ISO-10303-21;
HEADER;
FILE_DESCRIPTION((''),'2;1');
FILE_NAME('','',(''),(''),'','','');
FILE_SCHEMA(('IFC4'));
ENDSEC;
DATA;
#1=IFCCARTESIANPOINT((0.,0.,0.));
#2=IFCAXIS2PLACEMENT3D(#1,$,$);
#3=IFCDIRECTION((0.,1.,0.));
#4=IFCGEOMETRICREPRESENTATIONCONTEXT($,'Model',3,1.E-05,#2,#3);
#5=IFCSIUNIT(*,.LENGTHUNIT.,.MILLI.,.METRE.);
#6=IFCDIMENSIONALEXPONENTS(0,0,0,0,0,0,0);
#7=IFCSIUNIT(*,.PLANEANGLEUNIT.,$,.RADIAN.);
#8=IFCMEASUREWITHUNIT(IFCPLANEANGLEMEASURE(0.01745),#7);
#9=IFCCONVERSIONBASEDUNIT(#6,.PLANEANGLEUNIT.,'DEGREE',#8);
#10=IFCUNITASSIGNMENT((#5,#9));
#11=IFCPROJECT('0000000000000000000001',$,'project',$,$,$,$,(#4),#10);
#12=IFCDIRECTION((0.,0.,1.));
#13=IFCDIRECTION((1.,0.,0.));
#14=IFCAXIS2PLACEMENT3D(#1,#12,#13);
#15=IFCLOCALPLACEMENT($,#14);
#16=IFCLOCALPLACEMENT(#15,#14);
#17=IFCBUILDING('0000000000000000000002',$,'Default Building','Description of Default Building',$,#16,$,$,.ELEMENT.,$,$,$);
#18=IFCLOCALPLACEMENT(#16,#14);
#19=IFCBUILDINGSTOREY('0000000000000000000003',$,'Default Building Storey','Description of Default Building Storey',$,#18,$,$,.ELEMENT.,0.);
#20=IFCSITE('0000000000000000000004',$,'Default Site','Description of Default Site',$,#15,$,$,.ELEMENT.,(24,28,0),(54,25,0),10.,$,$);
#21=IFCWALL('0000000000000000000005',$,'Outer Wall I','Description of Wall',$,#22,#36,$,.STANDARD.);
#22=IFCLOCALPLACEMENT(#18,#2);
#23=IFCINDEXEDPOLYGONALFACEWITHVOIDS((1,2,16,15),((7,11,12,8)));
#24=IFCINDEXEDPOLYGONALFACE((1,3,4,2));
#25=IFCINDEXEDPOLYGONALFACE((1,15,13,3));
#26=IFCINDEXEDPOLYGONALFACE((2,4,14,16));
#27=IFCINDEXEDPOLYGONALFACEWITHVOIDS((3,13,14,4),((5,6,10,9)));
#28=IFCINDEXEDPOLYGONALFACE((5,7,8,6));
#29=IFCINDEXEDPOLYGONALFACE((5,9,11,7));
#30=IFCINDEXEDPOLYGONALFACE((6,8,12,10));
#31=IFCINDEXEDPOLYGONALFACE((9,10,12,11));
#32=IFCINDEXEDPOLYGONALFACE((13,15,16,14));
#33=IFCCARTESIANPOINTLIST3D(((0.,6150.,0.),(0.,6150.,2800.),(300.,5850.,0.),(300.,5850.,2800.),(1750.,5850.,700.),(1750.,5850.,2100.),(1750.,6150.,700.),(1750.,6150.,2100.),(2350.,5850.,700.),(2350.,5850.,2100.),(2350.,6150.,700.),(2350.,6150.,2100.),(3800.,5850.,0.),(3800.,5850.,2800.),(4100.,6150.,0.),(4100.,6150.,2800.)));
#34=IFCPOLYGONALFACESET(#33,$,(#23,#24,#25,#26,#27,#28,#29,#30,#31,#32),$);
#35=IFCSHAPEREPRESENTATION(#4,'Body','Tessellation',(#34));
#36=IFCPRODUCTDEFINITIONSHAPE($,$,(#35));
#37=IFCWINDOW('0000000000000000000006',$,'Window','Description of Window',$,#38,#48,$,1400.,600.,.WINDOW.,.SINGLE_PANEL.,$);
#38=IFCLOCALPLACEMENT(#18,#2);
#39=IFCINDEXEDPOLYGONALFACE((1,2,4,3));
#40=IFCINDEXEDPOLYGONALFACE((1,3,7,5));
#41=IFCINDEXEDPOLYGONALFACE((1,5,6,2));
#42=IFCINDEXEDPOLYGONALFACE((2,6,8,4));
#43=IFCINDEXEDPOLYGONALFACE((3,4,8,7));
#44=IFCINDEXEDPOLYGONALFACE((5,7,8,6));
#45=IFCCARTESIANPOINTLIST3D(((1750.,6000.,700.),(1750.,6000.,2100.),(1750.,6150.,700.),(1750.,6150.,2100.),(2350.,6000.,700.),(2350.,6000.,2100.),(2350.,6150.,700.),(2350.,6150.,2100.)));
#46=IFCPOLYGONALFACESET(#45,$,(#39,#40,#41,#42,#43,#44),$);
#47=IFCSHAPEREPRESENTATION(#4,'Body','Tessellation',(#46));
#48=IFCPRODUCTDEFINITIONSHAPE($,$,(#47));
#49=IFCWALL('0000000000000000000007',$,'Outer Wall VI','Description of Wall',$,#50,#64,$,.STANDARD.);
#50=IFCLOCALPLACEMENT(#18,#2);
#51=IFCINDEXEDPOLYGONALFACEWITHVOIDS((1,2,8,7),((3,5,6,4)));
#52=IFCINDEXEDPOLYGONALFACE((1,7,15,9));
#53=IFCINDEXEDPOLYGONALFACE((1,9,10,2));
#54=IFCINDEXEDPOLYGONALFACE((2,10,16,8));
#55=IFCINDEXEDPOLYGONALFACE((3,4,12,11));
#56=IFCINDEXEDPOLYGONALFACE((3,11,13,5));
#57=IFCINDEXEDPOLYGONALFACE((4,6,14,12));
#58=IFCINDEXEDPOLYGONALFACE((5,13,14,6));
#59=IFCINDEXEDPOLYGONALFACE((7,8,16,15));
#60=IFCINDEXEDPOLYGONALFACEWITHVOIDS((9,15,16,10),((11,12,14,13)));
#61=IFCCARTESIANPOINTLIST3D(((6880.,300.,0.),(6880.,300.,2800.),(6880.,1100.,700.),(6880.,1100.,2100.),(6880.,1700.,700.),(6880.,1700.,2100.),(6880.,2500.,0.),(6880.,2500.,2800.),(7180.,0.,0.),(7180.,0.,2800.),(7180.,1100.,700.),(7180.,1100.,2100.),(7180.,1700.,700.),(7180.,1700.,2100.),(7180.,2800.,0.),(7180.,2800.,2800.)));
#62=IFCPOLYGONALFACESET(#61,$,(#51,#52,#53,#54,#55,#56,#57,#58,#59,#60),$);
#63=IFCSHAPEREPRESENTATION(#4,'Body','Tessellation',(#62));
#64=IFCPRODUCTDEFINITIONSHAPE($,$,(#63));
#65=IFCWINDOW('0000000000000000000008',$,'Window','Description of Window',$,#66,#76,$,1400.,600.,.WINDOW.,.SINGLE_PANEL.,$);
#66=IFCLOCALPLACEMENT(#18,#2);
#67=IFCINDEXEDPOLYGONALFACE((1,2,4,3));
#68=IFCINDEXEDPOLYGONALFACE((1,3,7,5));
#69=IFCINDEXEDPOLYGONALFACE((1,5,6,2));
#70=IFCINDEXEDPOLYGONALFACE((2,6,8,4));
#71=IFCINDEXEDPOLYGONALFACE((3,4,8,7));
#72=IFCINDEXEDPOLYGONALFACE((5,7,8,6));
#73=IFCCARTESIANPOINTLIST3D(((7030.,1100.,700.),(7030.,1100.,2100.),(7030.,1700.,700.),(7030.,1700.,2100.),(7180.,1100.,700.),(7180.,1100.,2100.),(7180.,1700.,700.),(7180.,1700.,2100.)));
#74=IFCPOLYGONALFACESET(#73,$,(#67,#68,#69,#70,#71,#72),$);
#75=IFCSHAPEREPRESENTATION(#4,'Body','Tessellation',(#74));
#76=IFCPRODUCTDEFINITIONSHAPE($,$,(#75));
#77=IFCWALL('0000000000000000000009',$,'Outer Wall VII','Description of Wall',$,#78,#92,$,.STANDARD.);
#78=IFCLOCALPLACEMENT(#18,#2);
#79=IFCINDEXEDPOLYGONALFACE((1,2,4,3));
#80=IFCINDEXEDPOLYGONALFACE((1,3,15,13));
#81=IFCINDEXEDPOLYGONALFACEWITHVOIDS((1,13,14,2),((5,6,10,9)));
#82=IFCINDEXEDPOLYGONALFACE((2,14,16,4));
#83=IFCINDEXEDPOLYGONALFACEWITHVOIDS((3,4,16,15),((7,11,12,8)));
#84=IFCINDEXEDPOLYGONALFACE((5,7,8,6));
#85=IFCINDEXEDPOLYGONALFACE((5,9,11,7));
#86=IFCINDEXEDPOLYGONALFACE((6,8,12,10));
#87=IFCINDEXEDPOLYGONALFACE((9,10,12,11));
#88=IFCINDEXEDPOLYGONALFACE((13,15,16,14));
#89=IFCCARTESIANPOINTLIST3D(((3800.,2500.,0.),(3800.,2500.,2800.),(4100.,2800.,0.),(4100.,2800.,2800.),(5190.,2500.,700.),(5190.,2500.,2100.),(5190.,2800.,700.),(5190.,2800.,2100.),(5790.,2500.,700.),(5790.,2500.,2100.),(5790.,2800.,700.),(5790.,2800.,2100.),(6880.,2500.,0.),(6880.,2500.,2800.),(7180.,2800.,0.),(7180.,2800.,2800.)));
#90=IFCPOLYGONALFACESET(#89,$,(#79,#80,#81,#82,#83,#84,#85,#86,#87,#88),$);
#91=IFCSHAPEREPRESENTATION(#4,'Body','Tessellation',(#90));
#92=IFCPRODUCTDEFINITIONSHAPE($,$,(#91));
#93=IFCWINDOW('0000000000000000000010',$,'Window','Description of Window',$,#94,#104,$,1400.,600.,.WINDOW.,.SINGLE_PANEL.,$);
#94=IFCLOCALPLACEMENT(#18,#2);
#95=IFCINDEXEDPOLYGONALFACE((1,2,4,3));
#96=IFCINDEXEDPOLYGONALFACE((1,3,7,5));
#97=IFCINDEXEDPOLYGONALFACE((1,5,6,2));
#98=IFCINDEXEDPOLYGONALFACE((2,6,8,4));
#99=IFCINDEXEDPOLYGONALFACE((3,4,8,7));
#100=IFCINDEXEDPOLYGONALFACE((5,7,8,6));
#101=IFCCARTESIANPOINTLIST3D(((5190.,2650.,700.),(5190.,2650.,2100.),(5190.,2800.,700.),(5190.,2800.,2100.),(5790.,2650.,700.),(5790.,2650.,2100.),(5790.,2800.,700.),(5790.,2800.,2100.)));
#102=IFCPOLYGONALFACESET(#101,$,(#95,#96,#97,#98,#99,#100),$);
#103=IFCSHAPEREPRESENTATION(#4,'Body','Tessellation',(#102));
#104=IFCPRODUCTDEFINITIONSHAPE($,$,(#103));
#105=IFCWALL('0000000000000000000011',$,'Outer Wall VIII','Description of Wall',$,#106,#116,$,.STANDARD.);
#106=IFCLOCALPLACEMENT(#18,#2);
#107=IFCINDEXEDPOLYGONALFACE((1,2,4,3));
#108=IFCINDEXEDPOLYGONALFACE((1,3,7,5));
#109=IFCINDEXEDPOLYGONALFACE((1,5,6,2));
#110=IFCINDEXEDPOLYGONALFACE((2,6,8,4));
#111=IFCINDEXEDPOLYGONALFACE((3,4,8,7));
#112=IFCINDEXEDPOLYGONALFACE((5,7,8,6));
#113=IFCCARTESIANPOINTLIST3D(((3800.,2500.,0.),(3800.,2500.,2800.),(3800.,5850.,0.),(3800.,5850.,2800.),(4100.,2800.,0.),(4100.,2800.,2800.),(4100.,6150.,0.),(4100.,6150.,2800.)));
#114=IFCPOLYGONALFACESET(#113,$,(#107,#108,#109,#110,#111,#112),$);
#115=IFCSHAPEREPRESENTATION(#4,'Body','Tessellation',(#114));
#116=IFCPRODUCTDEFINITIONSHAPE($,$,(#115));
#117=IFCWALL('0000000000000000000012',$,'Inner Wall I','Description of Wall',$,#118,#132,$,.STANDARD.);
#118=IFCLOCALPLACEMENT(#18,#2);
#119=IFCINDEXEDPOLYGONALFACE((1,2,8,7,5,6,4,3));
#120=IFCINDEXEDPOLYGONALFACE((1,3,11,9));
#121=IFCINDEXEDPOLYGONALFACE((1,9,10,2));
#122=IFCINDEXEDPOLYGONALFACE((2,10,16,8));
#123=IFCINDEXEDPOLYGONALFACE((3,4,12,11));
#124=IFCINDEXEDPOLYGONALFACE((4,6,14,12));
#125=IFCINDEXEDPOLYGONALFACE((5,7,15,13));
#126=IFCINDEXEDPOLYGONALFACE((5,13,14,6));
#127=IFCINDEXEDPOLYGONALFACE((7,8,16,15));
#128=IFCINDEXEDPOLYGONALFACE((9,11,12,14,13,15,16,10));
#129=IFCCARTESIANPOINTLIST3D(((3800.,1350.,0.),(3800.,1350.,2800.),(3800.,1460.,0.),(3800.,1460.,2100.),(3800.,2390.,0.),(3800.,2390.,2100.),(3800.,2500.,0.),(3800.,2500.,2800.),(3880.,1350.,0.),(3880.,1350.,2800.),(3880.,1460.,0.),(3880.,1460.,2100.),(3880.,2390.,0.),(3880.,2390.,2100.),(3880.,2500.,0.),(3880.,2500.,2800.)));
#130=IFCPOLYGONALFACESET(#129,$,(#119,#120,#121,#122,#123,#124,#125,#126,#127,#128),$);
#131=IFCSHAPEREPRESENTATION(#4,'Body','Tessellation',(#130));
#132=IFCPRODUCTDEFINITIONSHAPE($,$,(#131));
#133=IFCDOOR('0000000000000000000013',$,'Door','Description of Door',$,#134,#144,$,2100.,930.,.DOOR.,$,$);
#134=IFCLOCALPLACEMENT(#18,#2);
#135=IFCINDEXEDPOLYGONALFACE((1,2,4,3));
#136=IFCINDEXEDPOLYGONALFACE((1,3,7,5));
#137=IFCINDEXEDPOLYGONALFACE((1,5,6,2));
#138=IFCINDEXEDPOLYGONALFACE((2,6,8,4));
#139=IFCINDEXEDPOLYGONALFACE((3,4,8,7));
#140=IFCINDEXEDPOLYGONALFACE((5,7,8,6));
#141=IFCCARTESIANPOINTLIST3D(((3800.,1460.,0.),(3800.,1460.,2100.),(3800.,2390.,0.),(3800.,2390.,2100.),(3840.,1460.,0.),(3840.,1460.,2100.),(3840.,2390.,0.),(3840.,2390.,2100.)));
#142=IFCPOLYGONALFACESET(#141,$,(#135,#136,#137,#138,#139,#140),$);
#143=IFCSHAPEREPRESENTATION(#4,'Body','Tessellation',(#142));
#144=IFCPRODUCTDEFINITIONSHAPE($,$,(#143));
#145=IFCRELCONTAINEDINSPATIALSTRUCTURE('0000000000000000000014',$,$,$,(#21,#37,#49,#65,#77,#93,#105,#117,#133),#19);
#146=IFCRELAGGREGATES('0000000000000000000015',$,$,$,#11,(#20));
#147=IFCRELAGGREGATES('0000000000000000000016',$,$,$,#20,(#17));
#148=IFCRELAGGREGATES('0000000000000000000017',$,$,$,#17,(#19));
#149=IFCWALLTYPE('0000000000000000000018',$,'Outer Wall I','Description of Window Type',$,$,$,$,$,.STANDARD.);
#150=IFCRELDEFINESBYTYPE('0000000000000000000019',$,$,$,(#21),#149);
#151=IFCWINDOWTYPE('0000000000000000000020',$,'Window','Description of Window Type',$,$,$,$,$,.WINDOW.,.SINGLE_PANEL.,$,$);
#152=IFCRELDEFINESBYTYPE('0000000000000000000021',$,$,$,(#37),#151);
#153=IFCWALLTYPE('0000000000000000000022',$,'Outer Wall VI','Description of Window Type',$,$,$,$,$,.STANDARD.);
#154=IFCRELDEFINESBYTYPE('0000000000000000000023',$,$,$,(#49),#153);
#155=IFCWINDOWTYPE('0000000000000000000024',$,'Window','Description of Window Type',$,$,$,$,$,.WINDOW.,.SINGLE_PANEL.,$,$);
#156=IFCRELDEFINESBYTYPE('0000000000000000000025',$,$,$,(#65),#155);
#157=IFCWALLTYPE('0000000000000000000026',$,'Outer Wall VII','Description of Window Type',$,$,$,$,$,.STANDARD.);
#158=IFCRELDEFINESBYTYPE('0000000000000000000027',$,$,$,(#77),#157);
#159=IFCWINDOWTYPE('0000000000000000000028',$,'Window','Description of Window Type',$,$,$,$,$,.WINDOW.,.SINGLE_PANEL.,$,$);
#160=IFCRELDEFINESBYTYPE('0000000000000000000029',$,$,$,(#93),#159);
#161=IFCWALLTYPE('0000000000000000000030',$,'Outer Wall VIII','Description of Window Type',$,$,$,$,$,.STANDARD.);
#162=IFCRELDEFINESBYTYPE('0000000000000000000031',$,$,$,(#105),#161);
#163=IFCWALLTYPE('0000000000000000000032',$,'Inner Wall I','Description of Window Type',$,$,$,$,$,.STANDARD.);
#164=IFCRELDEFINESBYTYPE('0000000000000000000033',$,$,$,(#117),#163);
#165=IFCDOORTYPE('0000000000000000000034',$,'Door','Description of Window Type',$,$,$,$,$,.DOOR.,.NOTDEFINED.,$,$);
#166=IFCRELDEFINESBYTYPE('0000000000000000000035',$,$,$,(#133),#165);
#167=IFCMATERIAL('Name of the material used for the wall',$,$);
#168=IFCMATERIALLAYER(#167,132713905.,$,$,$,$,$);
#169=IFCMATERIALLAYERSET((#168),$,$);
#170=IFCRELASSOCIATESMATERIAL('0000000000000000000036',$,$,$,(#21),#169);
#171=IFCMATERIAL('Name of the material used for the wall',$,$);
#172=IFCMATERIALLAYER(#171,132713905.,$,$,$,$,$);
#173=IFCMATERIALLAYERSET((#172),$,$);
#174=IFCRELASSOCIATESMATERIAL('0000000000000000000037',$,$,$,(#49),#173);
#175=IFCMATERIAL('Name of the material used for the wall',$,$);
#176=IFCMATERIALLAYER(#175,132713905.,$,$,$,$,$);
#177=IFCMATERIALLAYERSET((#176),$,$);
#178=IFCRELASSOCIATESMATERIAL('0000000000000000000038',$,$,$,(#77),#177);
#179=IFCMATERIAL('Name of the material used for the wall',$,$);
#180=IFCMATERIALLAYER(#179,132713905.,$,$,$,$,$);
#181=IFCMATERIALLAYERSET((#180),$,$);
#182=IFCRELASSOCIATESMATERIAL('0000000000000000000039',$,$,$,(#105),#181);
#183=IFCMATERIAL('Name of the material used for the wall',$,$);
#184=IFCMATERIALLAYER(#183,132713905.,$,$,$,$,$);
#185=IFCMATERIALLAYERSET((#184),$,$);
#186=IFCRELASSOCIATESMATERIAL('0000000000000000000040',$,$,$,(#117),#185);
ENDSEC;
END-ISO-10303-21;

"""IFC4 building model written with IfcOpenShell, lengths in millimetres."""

from ifc_helpers import new_model, entity, si_unit, converted_unit, direction, frame, origin, origin_with_axes, place, context, project, spatial, polyline, outline, extrude, material, layer, layer_set, layer_usage, type_object, element, fill, save


model = new_model("IFC4")

# Units and contexts
model_context = context("Model", 3, precision=1e-05, world=origin(), true_north=direction((0.0, 1.0, 0.0)))
ifc_project = project(units=[si_unit("LENGTHUNIT", "METRE", prefix="MILLI"), converted_unit("PLANEANGLEUNIT", "DEGREE", entity("IfcPlaneAngleMeasure", 0.01745), si_unit("PLANEANGLEUNIT", "RADIAN"), dimensions=[0, 0, 0, 0, 0, 0, 0])], contexts=[model_context])

# Site, building, storey
site_placement = place(None, origin_with_axes())
site = spatial("IfcSite", under=ifc_project, at=site_placement, Name="Default Site", Description="Description of Default Site", CompositionType="ELEMENT", RefLatitude=(24, 28, 0), RefLongitude=(54, 25, 0), RefElevation=10.0)
building_placement = place(site_placement, origin_with_axes())
building = spatial("IfcBuilding", under=site, at=building_placement, Name="Default Building", Description="Description of Default Building", CompositionType="ELEMENT")
storey_placement = place(building_placement, origin_with_axes())
storey = spatial("IfcBuildingStorey", under=building, at=storey_placement, Name="Default Building Storey", Description="Description of Default Building Storey", CompositionType="ELEMENT", Elevation=0.0)

# Walls, openings, windows
ifc_material_1 = material(Name="Name of the material used for the wall")
ifc_layer_1 = layer(ifc_material_1, 132713905.0)
ifc_layer_set_1 = layer_set([ifc_layer_1])
ifc_layer_usage_1 = layer_usage(ifc_layer_set_1, "AXIS2", "POSITIVE", -66356952.5)
wall_type_1 = type_object("IfcWallType", Name="Outer Wall I", Description="Description of Window Type", PredefinedType="STANDARD")
wall_1_placement = place(storey_placement, frame((3950.0, 6000.0, 0.0), z_axis=(0.0, 0.0, 1.0), x_axis=(-1.0, 0.0, 0.0)))
wall_1 = element("IfcWall", 1, at=wall_1_placement, inside=storey, type_object=wall_type_1, material=ifc_layer_usage_1, Name="Outer Wall I", Description="Description of Wall", PredefinedType="STANDARD", context=model_context, shape_type="SweptSolid", body=[
    extrude(outline(polyline([(-150.0, -150.0), (150.0, 150.0), (3650.0, 150.0), (3950.0, -150.0), (-150.0, -150.0)])), origin_with_axes(), (0.0, 0.0, 1.0), 2800.0),
])
opening_1_placement = place(wall_1_placement, frame((1600.0, -150.0, 700.0), z_axis=(0.0, 0.0, 1.0), x_axis=(1.0, 0.0, 0.0)))
opening_1 = element("IfcOpeningElement", 2, at=opening_1_placement, cuts=wall_1, context=model_context, shape_type="SweptSolid", body=[
    extrude(outline(polyline([(0.0, 0.0), (0.0, 300.0), (600.0, 300.0), (600.0, 0.0), (0.0, 0.0)])), origin_with_axes(), (0.0, 0.0, 1.0), 1400.0),
])
window_type_1 = type_object("IfcWindowType", Name="Window", Description="Description of Window Type", PartitioningType="SINGLE_PANEL", PredefinedType="WINDOW")
window_1_placement = place(opening_1_placement, origin_with_axes())
window_1 = element("IfcWindow", 3, at=window_1_placement, inside=storey, type_object=window_type_1, Name="Window", Description="Description of Window", OverallHeight=1400.0, OverallWidth=600.0, PartitioningType="SINGLE_PANEL", PredefinedType="WINDOW", context=model_context, shape_type="SweptSolid", body=[
    extrude(outline(polyline([(0.0, 0.0), (0.0, 150.0), (600.0, 150.0), (600.0, 0.0), (0.0, 0.0)])), origin_with_axes(), (0.0, 0.0, 1.0), 1400.0),
])
fill(opening_1, window_1)
ifc_material_2 = material(Name="Name of the material used for the wall")
ifc_layer_2 = layer(ifc_material_2, 132713905.0)
ifc_layer_set_2 = layer_set([ifc_layer_2])
ifc_layer_usage_2 = layer_usage(ifc_layer_set_2, "AXIS2", "POSITIVE", -66356952.5)
wall_type_2 = type_object("IfcWallType", Name="Outer Wall VI", Description="Description of Window Type", PredefinedType="STANDARD")
wall_2_placement = place(storey_placement, frame((7030.0, 150.0, 0.0), z_axis=(0.0, 0.0, 1.0), x_axis=(0.0, 1.0, 0.0)))
wall_2 = element("IfcWall", 4, at=wall_2_placement, inside=storey, type_object=wall_type_2, material=ifc_layer_usage_2, Name="Outer Wall VI", Description="Description of Wall", PredefinedType="STANDARD", context=model_context, shape_type="SweptSolid", body=[
    extrude(outline(polyline([(-150.0, -150.0), (150.0, 150.0), (2350.0, 150.0), (2650.0, -150.0), (-150.0, -150.0)])), origin_with_axes(), (0.0, 0.0, 1.0), 2800.0),
])
opening_2_placement = place(wall_2_placement, frame((950.0, -150.0, 700.0), z_axis=(0.0, 0.0, 1.0), x_axis=(1.0, 0.0, 0.0)))
opening_2 = element("IfcOpeningElement", 5, at=opening_2_placement, cuts=wall_2, context=model_context, shape_type="SweptSolid", body=[
    extrude(outline(polyline([(0.0, 0.0), (0.0, 300.0), (600.0, 300.0), (600.0, 0.0), (0.0, 0.0)])), origin_with_axes(), (0.0, 0.0, 1.0), 1400.0),
])
window_type_2 = type_object("IfcWindowType", Name="Window", Description="Description of Window Type", PartitioningType="SINGLE_PANEL", PredefinedType="WINDOW")
window_2_placement = place(opening_2_placement, origin_with_axes())
window_2 = element("IfcWindow", 6, at=window_2_placement, inside=storey, type_object=window_type_2, Name="Window", Description="Description of Window", OverallHeight=1400.0, OverallWidth=600.0, PartitioningType="SINGLE_PANEL", PredefinedType="WINDOW", context=model_context, shape_type="SweptSolid", body=[
    extrude(outline(polyline([(0.0, 0.0), (0.0, 150.0), (600.0, 150.0), (600.0, 0.0), (0.0, 0.0)])), origin_with_axes(), (0.0, 0.0, 1.0), 1400.0),
])
fill(opening_2, window_2)
ifc_material_3 = material(Name="Name of the material used for the wall")
ifc_layer_3 = layer(ifc_material_3, 132713905.0)
ifc_layer_set_3 = layer_set([ifc_layer_3])
ifc_layer_usage_3 = layer_usage(ifc_layer_set_3, "AXIS2", "POSITIVE", -66356952.5)
wall_type_3 = type_object("IfcWallType", Name="Outer Wall VII", Description="Description of Window Type", PredefinedType="STANDARD")
wall_3_placement = place(storey_placement, frame((7030.0, 2650.0, 0.0), z_axis=(0.0, 0.0, 1.0), x_axis=(-1.0, 0.0, 0.0)))
wall_3 = element("IfcWall", 7, at=wall_3_placement, inside=storey, type_object=wall_type_3, material=ifc_layer_usage_3, Name="Outer Wall VII", Description="Description of Wall", PredefinedType="STANDARD", context=model_context, shape_type="SweptSolid", body=[
    extrude(outline(polyline([(-150.0, -150.0), (150.0, 150.0), (3230.0, 150.0), (2930.0, -150.0), (-150.0, -150.0)])), origin_with_axes(), (0.0, 0.0, 1.0), 2800.0),
])
opening_3_placement = place(wall_3_placement, frame((1240.0, -150.0, 700.0), z_axis=(0.0, 0.0, 1.0), x_axis=(1.0, 0.0, 0.0)))
opening_3 = element("IfcOpeningElement", 8, at=opening_3_placement, cuts=wall_3, context=model_context, shape_type="SweptSolid", body=[
    extrude(outline(polyline([(0.0, 0.0), (0.0, 300.0), (600.0, 300.0), (600.0, 0.0), (0.0, 0.0)])), origin_with_axes(), (0.0, 0.0, 1.0), 1400.0),
])
window_type_3 = type_object("IfcWindowType", Name="Window", Description="Description of Window Type", PartitioningType="SINGLE_PANEL", PredefinedType="WINDOW")
window_3_placement = place(opening_3_placement, origin_with_axes())
window_3 = element("IfcWindow", 9, at=window_3_placement, inside=storey, type_object=window_type_3, Name="Window", Description="Description of Window", OverallHeight=1400.0, OverallWidth=600.0, PartitioningType="SINGLE_PANEL", PredefinedType="WINDOW", context=model_context, shape_type="SweptSolid", body=[
    extrude(outline(polyline([(0.0, 0.0), (0.0, 150.0), (600.0, 150.0), (600.0, 0.0), (0.0, 0.0)])), origin_with_axes(), (0.0, 0.0, 1.0), 1400.0),
])
fill(opening_3, window_3)

# Wall
ifc_material_4 = material(Name="Name of the material used for the wall")
ifc_layer_4 = layer(ifc_material_4, 132713905.0)
ifc_layer_set_4 = layer_set([ifc_layer_4])
ifc_layer_usage_4 = layer_usage(ifc_layer_set_4, "AXIS2", "POSITIVE", -66356952.5)
wall_type_4 = type_object("IfcWallType", Name="Outer Wall VIII", Description="Description of Window Type", PredefinedType="STANDARD")
wall_4_placement = place(storey_placement, frame((3950.0, 2650.0, 0.0), z_axis=(0.0, 0.0, 1.0), x_axis=(0.0, 1.0, 0.0)))
element("IfcWall", 10, at=wall_4_placement, inside=storey, type_object=wall_type_4, material=ifc_layer_usage_4, Name="Outer Wall VIII", Description="Description of Wall", PredefinedType="STANDARD", context=model_context, shape_type="SweptSolid", body=[
    extrude(outline(polyline([(150.0, -150.0), (-150.0, 150.0), (3200.0, 150.0), (3500.0, -150.0), (150.0, -150.0)])), origin_with_axes(), (0.0, 0.0, 1.0), 2800.0),
])

# Wall, opening, door
ifc_material_5 = material(Name="Name of the material used for the wall")
ifc_layer_5 = layer(ifc_material_5, 132713905.0)
ifc_layer_set_5 = layer_set([ifc_layer_5])
ifc_layer_usage_5 = layer_usage(ifc_layer_set_5, "AXIS2", "POSITIVE", -66356952.5)
wall_type_5 = type_object("IfcWallType", Name="Inner Wall I", Description="Description of Window Type", PredefinedType="STANDARD")
wall_5_placement = place(storey_placement, frame((3840.0, 2500.0, 0.0), z_axis=(0.0, 0.0, 1.0), x_axis=(0.0, -1.0, 0.0)))
wall_5 = element("IfcWall", 11, at=wall_5_placement, inside=storey, type_object=wall_type_5, material=ifc_layer_usage_5, Name="Inner Wall I", Description="Description of Wall", PredefinedType="STANDARD", context=model_context, shape_type="SweptSolid", body=[
    extrude(outline(polyline([(0.0, -40.0), (0.0, 40.0), (1150.0, 40.0), (1150.0, -40.0), (0.0, -40.0)])), origin_with_axes(), (0.0, 0.0, 1.0), 2800.0),
])
opening_4_placement = place(wall_5_placement, frame((110.0, -40.0, 0.0), z_axis=(0.0, 0.0, 1.0), x_axis=(1.0, 0.0, 0.0)))
opening_4 = element("IfcOpeningElement", 12, at=opening_4_placement, cuts=wall_5, context=model_context, shape_type="SweptSolid", body=[
    extrude(outline(polyline([(0.0, 0.0), (0.0, 80.0), (930.0, 80.0), (930.0, 0.0), (0.0, 0.0)])), origin_with_axes(), (0.0, 0.0, 1.0), 2100.0),
])
door_type_1 = type_object("IfcDoorType", Name="Door", Description="Description of Window Type", PredefinedType="DOOR")
door_1_placement = place(opening_4_placement, origin_with_axes())
door_1 = element("IfcDoor", 13, at=door_1_placement, inside=storey, type_object=door_type_1, Name="Door", Description="Description of Door", OverallHeight=2100.0, OverallWidth=930.0, PredefinedType="DOOR", context=model_context, shape_type="SweptSolid", body=[
    extrude(outline(polyline([(0.0, 0.0), (0.0, 40.0), (930.0, 40.0), (930.0, 0.0), (0.0, 0.0)])), origin_with_axes(), (0.0, 0.0, 1.0), 2100.0),
])
fill(opening_4, door_1)

save(model, "model.ifc")
